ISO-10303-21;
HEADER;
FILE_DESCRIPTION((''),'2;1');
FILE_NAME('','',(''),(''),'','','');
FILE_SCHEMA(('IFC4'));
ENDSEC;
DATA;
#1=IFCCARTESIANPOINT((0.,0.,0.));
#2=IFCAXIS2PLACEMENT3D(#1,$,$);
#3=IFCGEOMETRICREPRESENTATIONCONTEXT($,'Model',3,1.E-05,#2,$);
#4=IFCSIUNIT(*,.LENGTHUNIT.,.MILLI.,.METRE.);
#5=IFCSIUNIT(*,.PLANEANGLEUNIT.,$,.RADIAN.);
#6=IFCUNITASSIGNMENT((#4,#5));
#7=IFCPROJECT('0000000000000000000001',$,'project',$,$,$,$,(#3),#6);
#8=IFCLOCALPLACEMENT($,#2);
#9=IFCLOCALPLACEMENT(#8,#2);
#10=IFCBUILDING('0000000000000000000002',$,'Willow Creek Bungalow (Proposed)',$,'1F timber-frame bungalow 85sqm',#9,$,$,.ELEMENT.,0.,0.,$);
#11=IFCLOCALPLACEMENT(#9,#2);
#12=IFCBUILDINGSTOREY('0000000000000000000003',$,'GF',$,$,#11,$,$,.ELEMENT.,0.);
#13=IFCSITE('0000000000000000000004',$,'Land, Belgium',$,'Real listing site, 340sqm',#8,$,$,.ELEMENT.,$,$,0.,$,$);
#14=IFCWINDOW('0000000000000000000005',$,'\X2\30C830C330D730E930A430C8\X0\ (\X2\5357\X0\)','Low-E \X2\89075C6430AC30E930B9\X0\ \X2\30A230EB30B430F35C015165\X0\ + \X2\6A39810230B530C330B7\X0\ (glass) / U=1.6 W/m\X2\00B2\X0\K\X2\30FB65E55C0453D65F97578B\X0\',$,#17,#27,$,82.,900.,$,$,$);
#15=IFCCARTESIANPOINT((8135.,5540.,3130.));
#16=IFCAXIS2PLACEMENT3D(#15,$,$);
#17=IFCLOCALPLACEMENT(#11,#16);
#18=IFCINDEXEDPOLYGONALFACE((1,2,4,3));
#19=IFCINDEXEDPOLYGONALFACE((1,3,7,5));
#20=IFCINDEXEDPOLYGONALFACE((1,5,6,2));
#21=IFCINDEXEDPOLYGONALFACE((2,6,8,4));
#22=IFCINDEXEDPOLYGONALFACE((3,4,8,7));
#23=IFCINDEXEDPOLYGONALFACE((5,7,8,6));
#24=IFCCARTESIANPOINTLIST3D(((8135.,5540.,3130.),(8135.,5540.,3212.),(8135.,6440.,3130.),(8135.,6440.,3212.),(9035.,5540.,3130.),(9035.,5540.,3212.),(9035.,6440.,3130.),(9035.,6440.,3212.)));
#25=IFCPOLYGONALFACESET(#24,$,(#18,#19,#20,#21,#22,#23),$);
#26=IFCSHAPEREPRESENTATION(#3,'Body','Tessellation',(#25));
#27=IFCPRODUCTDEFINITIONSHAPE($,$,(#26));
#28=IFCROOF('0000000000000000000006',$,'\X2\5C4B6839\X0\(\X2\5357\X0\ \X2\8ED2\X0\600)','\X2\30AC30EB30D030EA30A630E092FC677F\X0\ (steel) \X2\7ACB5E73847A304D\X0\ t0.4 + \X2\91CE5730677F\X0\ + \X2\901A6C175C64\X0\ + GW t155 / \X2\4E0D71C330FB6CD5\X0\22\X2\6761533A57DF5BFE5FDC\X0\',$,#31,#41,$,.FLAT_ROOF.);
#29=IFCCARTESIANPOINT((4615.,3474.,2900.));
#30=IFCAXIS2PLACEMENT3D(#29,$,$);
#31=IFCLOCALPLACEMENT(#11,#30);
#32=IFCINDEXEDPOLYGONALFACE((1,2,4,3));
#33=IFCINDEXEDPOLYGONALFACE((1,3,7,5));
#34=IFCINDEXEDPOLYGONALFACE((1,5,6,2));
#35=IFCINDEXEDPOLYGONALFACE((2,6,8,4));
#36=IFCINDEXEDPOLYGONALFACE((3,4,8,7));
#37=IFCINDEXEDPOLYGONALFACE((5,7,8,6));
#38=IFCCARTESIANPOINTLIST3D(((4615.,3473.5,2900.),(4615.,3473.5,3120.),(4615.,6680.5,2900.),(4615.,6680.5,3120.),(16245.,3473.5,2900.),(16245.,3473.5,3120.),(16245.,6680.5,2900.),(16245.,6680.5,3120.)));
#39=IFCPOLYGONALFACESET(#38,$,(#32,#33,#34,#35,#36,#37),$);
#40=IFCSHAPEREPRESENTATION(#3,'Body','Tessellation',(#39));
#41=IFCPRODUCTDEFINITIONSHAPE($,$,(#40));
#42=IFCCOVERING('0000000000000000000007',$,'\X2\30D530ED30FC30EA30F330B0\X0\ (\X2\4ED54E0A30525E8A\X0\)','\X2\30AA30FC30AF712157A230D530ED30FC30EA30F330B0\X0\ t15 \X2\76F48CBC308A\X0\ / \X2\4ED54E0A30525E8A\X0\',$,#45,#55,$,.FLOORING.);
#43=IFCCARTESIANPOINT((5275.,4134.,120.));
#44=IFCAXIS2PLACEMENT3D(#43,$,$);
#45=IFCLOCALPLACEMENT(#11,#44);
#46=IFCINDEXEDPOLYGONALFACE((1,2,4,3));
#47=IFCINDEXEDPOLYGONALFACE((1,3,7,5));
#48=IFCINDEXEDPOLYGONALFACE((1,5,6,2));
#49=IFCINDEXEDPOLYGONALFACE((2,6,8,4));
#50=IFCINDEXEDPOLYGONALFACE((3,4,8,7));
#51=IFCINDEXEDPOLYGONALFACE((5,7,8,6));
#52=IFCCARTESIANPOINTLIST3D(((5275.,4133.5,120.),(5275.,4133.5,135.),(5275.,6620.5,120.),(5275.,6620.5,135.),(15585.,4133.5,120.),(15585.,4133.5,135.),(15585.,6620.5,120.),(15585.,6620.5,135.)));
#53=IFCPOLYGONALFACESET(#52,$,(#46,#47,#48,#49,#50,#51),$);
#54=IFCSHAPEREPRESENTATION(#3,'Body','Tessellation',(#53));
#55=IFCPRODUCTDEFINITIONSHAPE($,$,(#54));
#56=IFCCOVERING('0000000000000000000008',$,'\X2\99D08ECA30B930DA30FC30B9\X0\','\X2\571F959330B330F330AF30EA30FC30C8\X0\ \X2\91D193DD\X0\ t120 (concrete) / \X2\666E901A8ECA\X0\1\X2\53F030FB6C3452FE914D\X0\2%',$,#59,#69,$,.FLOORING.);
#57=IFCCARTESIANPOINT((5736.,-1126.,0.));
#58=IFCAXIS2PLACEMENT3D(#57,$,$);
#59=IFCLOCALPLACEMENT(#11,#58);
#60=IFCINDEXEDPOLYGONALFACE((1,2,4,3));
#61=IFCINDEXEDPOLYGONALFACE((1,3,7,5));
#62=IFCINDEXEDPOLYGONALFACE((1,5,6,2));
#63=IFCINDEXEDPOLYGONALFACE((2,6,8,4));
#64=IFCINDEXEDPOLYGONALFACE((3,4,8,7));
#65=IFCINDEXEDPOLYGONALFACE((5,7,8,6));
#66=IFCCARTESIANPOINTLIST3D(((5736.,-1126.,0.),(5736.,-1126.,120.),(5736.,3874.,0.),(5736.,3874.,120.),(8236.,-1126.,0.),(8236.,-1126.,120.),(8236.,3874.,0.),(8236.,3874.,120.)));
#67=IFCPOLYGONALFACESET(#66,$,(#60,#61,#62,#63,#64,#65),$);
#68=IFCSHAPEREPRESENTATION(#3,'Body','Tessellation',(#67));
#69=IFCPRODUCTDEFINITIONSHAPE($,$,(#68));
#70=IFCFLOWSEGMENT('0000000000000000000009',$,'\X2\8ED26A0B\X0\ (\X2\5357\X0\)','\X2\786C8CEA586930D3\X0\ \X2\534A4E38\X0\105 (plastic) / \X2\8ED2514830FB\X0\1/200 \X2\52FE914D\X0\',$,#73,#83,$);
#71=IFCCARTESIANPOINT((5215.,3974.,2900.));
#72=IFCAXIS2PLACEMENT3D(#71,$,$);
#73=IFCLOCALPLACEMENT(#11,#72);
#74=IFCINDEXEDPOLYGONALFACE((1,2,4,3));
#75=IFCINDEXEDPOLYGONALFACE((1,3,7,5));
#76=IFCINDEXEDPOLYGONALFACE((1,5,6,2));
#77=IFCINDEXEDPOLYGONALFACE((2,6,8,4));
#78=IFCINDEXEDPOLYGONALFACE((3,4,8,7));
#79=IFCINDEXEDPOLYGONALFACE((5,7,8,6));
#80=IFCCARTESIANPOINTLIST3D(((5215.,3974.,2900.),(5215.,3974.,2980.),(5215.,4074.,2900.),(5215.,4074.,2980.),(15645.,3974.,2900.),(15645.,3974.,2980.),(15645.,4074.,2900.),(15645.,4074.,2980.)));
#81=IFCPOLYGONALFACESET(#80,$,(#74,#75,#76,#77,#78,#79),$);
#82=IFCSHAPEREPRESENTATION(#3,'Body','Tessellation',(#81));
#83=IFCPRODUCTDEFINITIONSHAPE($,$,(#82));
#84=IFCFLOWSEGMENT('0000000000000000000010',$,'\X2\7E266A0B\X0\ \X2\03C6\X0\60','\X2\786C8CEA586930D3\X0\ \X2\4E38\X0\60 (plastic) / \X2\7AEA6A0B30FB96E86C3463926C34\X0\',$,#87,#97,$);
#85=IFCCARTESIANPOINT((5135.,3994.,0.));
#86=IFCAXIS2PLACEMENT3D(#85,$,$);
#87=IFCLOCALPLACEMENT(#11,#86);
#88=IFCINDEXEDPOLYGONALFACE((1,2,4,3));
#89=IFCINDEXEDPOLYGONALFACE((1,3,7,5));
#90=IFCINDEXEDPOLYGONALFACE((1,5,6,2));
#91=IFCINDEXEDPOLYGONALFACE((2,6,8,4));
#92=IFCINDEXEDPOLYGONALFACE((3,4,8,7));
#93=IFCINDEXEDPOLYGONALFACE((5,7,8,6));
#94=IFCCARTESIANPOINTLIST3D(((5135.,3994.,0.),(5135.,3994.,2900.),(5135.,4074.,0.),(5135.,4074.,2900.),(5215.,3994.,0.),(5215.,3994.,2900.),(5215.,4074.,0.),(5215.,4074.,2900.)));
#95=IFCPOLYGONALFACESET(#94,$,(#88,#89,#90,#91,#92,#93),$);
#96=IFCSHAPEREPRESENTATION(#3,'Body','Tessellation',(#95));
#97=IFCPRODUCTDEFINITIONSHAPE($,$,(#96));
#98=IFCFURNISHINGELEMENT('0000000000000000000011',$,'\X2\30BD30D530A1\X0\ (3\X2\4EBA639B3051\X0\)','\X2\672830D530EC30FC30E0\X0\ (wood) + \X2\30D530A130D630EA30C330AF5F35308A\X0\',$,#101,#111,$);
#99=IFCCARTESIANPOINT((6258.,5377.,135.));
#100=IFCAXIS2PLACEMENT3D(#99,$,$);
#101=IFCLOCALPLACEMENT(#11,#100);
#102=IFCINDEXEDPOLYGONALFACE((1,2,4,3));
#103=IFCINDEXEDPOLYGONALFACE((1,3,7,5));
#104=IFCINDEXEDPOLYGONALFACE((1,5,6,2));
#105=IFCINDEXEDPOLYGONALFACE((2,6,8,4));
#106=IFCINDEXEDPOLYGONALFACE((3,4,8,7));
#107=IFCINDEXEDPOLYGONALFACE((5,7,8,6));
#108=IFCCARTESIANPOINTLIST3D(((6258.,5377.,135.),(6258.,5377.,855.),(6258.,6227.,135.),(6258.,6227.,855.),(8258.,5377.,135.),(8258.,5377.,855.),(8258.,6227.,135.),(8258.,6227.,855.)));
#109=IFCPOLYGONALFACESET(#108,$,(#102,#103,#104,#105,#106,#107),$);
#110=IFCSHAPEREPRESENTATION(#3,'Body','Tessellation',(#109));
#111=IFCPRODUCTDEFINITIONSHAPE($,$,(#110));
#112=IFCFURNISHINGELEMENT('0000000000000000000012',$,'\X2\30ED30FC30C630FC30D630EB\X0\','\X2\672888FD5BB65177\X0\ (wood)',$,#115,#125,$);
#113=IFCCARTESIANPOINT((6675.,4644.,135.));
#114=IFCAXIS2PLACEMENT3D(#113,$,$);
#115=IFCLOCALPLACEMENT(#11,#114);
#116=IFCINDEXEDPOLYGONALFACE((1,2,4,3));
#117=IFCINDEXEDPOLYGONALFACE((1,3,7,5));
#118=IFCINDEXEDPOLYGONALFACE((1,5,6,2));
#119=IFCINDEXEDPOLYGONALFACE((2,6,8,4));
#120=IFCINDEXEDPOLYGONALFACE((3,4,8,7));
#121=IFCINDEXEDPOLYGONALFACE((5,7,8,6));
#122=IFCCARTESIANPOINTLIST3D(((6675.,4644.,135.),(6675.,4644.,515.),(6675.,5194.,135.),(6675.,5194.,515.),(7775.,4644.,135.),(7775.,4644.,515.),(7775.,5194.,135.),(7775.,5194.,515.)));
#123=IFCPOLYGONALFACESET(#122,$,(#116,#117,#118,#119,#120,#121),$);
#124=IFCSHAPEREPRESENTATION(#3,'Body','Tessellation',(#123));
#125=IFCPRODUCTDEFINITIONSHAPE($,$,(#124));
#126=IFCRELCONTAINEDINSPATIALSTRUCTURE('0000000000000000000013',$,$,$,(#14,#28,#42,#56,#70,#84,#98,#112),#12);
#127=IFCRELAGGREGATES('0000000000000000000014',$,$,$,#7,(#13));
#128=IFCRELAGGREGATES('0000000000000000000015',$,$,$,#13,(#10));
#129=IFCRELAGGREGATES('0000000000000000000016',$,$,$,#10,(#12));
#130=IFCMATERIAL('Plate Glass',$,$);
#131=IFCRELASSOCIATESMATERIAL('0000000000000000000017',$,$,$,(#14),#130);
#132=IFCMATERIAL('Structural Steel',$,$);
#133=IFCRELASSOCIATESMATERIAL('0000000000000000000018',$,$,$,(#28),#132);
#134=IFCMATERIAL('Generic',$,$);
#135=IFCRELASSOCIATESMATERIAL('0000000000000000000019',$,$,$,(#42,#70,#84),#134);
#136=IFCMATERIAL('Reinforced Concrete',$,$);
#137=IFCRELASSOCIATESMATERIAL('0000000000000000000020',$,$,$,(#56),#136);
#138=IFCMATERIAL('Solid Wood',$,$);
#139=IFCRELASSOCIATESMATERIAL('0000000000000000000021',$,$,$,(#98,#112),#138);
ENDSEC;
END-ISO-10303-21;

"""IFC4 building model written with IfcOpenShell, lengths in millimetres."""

from ifc_helpers import new_model, si_unit, frame, frame_2d, origin, place, context, project, spatial, rectangle, extrude, material, element, save


model = new_model("IFC4")

# Units and contexts
model_context = context("Model", 3, precision=1e-05, world=origin())
ifc_project = project(units=[si_unit("LENGTHUNIT", "METRE", prefix="MILLI"), si_unit("PLANEANGLEUNIT", "RADIAN")], contexts=[model_context])

# Site, building, storey
site_placement = place(None, origin())
site = spatial("IfcSite", under=ifc_project, at=site_placement, Name="Land, Belgium", ObjectType="Real listing site, 340sqm", CompositionType="ELEMENT", RefElevation=0.0)
building_placement = place(site_placement, origin())
building = spatial("IfcBuilding", under=site, at=building_placement, Name="Willow Creek Bungalow (Proposed)", ObjectType="1F timber-frame bungalow 85sqm", CompositionType="ELEMENT", ElevationOfRefHeight=0.0, ElevationOfTerrain=0.0)
storey_placement = place(building_placement, origin())
storey = spatial("IfcBuildingStorey", under=building, at=storey_placement, Name="GF", CompositionType="ELEMENT", Elevation=0.0)

# Shared definitions
ifc_material_1 = material(Name="Solid Wood")

# Shared definitions
ifc_material_2 = material(Name="Reinforced Concrete")

# Shared definitions
ifc_material_3 = material(Name="Plate Glass")

# Window
window_1_placement = place(storey_placement, frame((8135.0, 5540.0, 3130.0)))
element("IfcWindow", 1, at=window_1_placement, inside=storey, material=ifc_material_3, Name="トップライト (南)", Description="Low-E 複層ガラス アルゴン封入 + 樹脂サッシ (glass) / U=1.6 W/m²K・日射取得型", OverallHeight=82.0, OverallWidth=900.0, context=model_context, shape_type="SweptSolid", body=[
    extrude(rectangle(XDim=900.0, YDim=900.0, at=frame_2d((450.0, 450.0))), frame((8135.0, 5540.0, 3130.0)), (0.0, 0.0, 1.0), 82.0),
])

# Roof
ifc_material_4 = material(Name="Structural Steel")
roof_1_placement = place(storey_placement, frame((4615.0, 3474.0, 2900.0)))
element("IfcRoof", 2, at=roof_1_placement, inside=storey, material=ifc_material_4, Name="屋根(南 軒600)", Description="ガルバリウム鋼板 (steel) 立平葺き t0.4 + 野地板 + 通気層 + GW t155 / 不燃・法22条区域対応", PredefinedType="FLAT_ROOF", context=model_context, shape_type="SweptSolid", body=[
    extrude(rectangle(XDim=11630.0, YDim=3207.0, at=frame_2d((5815.0, 1603.0))), frame((4615.0, 3474.0, 2900.0)), (0.0, 0.0, 1.0), 220.0),
])

# Coverings
ifc_material_5 = material(Name="Generic")
covering_1_placement = place(storey_placement, frame((5275.0, 4134.0, 120.0)))
element("IfcCovering", 3, at=covering_1_placement, inside=storey, material=ifc_material_5, Name="フローリング (仕上げ床)", Description="オーク無垢フローリング t15 直貼り / 仕上げ床", PredefinedType="FLOORING", context=model_context, shape_type="SweptSolid", body=[
    extrude(rectangle(XDim=10310.0, YDim=2487.0, at=frame_2d((5155.0, 1243.0))), frame((5275.0, 4134.0, 120.0)), (0.0, 0.0, 1.0), 15.0),
])
covering_2_placement = place(storey_placement, frame((5736.0, -1126.0, 0.0)))
element("IfcCovering", 4, at=covering_2_placement, inside=storey, material=ifc_material_2, Name="駐車スペース", Description="土間コンクリート 金鏝 t120 (concrete) / 普通車1台・水勾配2%", PredefinedType="FLOORING", context=model_context, shape_type="SweptSolid", body=[
    extrude(rectangle(XDim=2500.0, YDim=5000.0, at=frame_2d((1250.0, 2500.0))), frame((5736.0, -1126.0, 0.0)), (0.0, 0.0, 1.0), 120.0),
])

# Flow segments
flow_segment_1_placement = place(storey_placement, frame((5215.0, 3974.0, 2900.0)))
element("IfcFlowSegment", 5, at=flow_segment_1_placement, inside=storey, material=ifc_material_5, Name="軒樋 (南)", Description="硬質塩ビ 半丸105 (plastic) / 軒先・1/200 勾配", context=model_context, shape_type="SweptSolid", body=[
    extrude(rectangle(XDim=10430.0, YDim=100.0, at=frame_2d((5215.0, 50.0))), frame((5215.0, 3974.0, 2900.0)), (0.0, 0.0, 1.0), 80.0),
])
flow_segment_2_placement = place(storey_placement, frame((5135.0, 3994.0, 0.0)))
element("IfcFlowSegment", 6, at=flow_segment_2_placement, inside=storey, material=ifc_material_5, Name="縦樋 φ60", Description="硬質塩ビ 丸60 (plastic) / 竪樋・雨水排水", context=model_context, shape_type="SweptSolid", body=[
    extrude(rectangle(XDim=80.0, YDim=80.0, at=frame_2d((40.0, 40.0))), frame((5135.0, 3994.0, 0.0)), (0.0, 0.0, 1.0), 2900.0),
])

# Furnishing elements
furnishing_1_placement = place(storey_placement, frame((6258.0, 5377.0, 135.0)))
element("IfcFurnishingElement", 7, at=furnishing_1_placement, inside=storey, material=ifc_material_1, Name="ソファ (3人掛け)", Description="木フレーム (wood) + ファブリック張り", context=model_context, shape_type="SweptSolid", body=[
    extrude(rectangle(XDim=2000.0, YDim=850.0, at=frame_2d((1000.0, 425.0))), frame((6258.0, 5377.0, 135.0)), (0.0, 0.0, 1.0), 720.0),
])
furnishing_2_placement = place(storey_placement, frame((6675.0, 4644.0, 135.0)))
element("IfcFurnishingElement", 8, at=furnishing_2_placement, inside=storey, material=ifc_material_1, Name="ローテーブル", Description="木製家具 (wood)", context=model_context, shape_type="SweptSolid", body=[
    extrude(rectangle(XDim=1100.0, YDim=550.0, at=frame_2d((550.0, 275.0))), frame((6675.0, 4644.0, 135.0)), (0.0, 0.0, 1.0), 380.0),
])

save(model, "model.ifc")
